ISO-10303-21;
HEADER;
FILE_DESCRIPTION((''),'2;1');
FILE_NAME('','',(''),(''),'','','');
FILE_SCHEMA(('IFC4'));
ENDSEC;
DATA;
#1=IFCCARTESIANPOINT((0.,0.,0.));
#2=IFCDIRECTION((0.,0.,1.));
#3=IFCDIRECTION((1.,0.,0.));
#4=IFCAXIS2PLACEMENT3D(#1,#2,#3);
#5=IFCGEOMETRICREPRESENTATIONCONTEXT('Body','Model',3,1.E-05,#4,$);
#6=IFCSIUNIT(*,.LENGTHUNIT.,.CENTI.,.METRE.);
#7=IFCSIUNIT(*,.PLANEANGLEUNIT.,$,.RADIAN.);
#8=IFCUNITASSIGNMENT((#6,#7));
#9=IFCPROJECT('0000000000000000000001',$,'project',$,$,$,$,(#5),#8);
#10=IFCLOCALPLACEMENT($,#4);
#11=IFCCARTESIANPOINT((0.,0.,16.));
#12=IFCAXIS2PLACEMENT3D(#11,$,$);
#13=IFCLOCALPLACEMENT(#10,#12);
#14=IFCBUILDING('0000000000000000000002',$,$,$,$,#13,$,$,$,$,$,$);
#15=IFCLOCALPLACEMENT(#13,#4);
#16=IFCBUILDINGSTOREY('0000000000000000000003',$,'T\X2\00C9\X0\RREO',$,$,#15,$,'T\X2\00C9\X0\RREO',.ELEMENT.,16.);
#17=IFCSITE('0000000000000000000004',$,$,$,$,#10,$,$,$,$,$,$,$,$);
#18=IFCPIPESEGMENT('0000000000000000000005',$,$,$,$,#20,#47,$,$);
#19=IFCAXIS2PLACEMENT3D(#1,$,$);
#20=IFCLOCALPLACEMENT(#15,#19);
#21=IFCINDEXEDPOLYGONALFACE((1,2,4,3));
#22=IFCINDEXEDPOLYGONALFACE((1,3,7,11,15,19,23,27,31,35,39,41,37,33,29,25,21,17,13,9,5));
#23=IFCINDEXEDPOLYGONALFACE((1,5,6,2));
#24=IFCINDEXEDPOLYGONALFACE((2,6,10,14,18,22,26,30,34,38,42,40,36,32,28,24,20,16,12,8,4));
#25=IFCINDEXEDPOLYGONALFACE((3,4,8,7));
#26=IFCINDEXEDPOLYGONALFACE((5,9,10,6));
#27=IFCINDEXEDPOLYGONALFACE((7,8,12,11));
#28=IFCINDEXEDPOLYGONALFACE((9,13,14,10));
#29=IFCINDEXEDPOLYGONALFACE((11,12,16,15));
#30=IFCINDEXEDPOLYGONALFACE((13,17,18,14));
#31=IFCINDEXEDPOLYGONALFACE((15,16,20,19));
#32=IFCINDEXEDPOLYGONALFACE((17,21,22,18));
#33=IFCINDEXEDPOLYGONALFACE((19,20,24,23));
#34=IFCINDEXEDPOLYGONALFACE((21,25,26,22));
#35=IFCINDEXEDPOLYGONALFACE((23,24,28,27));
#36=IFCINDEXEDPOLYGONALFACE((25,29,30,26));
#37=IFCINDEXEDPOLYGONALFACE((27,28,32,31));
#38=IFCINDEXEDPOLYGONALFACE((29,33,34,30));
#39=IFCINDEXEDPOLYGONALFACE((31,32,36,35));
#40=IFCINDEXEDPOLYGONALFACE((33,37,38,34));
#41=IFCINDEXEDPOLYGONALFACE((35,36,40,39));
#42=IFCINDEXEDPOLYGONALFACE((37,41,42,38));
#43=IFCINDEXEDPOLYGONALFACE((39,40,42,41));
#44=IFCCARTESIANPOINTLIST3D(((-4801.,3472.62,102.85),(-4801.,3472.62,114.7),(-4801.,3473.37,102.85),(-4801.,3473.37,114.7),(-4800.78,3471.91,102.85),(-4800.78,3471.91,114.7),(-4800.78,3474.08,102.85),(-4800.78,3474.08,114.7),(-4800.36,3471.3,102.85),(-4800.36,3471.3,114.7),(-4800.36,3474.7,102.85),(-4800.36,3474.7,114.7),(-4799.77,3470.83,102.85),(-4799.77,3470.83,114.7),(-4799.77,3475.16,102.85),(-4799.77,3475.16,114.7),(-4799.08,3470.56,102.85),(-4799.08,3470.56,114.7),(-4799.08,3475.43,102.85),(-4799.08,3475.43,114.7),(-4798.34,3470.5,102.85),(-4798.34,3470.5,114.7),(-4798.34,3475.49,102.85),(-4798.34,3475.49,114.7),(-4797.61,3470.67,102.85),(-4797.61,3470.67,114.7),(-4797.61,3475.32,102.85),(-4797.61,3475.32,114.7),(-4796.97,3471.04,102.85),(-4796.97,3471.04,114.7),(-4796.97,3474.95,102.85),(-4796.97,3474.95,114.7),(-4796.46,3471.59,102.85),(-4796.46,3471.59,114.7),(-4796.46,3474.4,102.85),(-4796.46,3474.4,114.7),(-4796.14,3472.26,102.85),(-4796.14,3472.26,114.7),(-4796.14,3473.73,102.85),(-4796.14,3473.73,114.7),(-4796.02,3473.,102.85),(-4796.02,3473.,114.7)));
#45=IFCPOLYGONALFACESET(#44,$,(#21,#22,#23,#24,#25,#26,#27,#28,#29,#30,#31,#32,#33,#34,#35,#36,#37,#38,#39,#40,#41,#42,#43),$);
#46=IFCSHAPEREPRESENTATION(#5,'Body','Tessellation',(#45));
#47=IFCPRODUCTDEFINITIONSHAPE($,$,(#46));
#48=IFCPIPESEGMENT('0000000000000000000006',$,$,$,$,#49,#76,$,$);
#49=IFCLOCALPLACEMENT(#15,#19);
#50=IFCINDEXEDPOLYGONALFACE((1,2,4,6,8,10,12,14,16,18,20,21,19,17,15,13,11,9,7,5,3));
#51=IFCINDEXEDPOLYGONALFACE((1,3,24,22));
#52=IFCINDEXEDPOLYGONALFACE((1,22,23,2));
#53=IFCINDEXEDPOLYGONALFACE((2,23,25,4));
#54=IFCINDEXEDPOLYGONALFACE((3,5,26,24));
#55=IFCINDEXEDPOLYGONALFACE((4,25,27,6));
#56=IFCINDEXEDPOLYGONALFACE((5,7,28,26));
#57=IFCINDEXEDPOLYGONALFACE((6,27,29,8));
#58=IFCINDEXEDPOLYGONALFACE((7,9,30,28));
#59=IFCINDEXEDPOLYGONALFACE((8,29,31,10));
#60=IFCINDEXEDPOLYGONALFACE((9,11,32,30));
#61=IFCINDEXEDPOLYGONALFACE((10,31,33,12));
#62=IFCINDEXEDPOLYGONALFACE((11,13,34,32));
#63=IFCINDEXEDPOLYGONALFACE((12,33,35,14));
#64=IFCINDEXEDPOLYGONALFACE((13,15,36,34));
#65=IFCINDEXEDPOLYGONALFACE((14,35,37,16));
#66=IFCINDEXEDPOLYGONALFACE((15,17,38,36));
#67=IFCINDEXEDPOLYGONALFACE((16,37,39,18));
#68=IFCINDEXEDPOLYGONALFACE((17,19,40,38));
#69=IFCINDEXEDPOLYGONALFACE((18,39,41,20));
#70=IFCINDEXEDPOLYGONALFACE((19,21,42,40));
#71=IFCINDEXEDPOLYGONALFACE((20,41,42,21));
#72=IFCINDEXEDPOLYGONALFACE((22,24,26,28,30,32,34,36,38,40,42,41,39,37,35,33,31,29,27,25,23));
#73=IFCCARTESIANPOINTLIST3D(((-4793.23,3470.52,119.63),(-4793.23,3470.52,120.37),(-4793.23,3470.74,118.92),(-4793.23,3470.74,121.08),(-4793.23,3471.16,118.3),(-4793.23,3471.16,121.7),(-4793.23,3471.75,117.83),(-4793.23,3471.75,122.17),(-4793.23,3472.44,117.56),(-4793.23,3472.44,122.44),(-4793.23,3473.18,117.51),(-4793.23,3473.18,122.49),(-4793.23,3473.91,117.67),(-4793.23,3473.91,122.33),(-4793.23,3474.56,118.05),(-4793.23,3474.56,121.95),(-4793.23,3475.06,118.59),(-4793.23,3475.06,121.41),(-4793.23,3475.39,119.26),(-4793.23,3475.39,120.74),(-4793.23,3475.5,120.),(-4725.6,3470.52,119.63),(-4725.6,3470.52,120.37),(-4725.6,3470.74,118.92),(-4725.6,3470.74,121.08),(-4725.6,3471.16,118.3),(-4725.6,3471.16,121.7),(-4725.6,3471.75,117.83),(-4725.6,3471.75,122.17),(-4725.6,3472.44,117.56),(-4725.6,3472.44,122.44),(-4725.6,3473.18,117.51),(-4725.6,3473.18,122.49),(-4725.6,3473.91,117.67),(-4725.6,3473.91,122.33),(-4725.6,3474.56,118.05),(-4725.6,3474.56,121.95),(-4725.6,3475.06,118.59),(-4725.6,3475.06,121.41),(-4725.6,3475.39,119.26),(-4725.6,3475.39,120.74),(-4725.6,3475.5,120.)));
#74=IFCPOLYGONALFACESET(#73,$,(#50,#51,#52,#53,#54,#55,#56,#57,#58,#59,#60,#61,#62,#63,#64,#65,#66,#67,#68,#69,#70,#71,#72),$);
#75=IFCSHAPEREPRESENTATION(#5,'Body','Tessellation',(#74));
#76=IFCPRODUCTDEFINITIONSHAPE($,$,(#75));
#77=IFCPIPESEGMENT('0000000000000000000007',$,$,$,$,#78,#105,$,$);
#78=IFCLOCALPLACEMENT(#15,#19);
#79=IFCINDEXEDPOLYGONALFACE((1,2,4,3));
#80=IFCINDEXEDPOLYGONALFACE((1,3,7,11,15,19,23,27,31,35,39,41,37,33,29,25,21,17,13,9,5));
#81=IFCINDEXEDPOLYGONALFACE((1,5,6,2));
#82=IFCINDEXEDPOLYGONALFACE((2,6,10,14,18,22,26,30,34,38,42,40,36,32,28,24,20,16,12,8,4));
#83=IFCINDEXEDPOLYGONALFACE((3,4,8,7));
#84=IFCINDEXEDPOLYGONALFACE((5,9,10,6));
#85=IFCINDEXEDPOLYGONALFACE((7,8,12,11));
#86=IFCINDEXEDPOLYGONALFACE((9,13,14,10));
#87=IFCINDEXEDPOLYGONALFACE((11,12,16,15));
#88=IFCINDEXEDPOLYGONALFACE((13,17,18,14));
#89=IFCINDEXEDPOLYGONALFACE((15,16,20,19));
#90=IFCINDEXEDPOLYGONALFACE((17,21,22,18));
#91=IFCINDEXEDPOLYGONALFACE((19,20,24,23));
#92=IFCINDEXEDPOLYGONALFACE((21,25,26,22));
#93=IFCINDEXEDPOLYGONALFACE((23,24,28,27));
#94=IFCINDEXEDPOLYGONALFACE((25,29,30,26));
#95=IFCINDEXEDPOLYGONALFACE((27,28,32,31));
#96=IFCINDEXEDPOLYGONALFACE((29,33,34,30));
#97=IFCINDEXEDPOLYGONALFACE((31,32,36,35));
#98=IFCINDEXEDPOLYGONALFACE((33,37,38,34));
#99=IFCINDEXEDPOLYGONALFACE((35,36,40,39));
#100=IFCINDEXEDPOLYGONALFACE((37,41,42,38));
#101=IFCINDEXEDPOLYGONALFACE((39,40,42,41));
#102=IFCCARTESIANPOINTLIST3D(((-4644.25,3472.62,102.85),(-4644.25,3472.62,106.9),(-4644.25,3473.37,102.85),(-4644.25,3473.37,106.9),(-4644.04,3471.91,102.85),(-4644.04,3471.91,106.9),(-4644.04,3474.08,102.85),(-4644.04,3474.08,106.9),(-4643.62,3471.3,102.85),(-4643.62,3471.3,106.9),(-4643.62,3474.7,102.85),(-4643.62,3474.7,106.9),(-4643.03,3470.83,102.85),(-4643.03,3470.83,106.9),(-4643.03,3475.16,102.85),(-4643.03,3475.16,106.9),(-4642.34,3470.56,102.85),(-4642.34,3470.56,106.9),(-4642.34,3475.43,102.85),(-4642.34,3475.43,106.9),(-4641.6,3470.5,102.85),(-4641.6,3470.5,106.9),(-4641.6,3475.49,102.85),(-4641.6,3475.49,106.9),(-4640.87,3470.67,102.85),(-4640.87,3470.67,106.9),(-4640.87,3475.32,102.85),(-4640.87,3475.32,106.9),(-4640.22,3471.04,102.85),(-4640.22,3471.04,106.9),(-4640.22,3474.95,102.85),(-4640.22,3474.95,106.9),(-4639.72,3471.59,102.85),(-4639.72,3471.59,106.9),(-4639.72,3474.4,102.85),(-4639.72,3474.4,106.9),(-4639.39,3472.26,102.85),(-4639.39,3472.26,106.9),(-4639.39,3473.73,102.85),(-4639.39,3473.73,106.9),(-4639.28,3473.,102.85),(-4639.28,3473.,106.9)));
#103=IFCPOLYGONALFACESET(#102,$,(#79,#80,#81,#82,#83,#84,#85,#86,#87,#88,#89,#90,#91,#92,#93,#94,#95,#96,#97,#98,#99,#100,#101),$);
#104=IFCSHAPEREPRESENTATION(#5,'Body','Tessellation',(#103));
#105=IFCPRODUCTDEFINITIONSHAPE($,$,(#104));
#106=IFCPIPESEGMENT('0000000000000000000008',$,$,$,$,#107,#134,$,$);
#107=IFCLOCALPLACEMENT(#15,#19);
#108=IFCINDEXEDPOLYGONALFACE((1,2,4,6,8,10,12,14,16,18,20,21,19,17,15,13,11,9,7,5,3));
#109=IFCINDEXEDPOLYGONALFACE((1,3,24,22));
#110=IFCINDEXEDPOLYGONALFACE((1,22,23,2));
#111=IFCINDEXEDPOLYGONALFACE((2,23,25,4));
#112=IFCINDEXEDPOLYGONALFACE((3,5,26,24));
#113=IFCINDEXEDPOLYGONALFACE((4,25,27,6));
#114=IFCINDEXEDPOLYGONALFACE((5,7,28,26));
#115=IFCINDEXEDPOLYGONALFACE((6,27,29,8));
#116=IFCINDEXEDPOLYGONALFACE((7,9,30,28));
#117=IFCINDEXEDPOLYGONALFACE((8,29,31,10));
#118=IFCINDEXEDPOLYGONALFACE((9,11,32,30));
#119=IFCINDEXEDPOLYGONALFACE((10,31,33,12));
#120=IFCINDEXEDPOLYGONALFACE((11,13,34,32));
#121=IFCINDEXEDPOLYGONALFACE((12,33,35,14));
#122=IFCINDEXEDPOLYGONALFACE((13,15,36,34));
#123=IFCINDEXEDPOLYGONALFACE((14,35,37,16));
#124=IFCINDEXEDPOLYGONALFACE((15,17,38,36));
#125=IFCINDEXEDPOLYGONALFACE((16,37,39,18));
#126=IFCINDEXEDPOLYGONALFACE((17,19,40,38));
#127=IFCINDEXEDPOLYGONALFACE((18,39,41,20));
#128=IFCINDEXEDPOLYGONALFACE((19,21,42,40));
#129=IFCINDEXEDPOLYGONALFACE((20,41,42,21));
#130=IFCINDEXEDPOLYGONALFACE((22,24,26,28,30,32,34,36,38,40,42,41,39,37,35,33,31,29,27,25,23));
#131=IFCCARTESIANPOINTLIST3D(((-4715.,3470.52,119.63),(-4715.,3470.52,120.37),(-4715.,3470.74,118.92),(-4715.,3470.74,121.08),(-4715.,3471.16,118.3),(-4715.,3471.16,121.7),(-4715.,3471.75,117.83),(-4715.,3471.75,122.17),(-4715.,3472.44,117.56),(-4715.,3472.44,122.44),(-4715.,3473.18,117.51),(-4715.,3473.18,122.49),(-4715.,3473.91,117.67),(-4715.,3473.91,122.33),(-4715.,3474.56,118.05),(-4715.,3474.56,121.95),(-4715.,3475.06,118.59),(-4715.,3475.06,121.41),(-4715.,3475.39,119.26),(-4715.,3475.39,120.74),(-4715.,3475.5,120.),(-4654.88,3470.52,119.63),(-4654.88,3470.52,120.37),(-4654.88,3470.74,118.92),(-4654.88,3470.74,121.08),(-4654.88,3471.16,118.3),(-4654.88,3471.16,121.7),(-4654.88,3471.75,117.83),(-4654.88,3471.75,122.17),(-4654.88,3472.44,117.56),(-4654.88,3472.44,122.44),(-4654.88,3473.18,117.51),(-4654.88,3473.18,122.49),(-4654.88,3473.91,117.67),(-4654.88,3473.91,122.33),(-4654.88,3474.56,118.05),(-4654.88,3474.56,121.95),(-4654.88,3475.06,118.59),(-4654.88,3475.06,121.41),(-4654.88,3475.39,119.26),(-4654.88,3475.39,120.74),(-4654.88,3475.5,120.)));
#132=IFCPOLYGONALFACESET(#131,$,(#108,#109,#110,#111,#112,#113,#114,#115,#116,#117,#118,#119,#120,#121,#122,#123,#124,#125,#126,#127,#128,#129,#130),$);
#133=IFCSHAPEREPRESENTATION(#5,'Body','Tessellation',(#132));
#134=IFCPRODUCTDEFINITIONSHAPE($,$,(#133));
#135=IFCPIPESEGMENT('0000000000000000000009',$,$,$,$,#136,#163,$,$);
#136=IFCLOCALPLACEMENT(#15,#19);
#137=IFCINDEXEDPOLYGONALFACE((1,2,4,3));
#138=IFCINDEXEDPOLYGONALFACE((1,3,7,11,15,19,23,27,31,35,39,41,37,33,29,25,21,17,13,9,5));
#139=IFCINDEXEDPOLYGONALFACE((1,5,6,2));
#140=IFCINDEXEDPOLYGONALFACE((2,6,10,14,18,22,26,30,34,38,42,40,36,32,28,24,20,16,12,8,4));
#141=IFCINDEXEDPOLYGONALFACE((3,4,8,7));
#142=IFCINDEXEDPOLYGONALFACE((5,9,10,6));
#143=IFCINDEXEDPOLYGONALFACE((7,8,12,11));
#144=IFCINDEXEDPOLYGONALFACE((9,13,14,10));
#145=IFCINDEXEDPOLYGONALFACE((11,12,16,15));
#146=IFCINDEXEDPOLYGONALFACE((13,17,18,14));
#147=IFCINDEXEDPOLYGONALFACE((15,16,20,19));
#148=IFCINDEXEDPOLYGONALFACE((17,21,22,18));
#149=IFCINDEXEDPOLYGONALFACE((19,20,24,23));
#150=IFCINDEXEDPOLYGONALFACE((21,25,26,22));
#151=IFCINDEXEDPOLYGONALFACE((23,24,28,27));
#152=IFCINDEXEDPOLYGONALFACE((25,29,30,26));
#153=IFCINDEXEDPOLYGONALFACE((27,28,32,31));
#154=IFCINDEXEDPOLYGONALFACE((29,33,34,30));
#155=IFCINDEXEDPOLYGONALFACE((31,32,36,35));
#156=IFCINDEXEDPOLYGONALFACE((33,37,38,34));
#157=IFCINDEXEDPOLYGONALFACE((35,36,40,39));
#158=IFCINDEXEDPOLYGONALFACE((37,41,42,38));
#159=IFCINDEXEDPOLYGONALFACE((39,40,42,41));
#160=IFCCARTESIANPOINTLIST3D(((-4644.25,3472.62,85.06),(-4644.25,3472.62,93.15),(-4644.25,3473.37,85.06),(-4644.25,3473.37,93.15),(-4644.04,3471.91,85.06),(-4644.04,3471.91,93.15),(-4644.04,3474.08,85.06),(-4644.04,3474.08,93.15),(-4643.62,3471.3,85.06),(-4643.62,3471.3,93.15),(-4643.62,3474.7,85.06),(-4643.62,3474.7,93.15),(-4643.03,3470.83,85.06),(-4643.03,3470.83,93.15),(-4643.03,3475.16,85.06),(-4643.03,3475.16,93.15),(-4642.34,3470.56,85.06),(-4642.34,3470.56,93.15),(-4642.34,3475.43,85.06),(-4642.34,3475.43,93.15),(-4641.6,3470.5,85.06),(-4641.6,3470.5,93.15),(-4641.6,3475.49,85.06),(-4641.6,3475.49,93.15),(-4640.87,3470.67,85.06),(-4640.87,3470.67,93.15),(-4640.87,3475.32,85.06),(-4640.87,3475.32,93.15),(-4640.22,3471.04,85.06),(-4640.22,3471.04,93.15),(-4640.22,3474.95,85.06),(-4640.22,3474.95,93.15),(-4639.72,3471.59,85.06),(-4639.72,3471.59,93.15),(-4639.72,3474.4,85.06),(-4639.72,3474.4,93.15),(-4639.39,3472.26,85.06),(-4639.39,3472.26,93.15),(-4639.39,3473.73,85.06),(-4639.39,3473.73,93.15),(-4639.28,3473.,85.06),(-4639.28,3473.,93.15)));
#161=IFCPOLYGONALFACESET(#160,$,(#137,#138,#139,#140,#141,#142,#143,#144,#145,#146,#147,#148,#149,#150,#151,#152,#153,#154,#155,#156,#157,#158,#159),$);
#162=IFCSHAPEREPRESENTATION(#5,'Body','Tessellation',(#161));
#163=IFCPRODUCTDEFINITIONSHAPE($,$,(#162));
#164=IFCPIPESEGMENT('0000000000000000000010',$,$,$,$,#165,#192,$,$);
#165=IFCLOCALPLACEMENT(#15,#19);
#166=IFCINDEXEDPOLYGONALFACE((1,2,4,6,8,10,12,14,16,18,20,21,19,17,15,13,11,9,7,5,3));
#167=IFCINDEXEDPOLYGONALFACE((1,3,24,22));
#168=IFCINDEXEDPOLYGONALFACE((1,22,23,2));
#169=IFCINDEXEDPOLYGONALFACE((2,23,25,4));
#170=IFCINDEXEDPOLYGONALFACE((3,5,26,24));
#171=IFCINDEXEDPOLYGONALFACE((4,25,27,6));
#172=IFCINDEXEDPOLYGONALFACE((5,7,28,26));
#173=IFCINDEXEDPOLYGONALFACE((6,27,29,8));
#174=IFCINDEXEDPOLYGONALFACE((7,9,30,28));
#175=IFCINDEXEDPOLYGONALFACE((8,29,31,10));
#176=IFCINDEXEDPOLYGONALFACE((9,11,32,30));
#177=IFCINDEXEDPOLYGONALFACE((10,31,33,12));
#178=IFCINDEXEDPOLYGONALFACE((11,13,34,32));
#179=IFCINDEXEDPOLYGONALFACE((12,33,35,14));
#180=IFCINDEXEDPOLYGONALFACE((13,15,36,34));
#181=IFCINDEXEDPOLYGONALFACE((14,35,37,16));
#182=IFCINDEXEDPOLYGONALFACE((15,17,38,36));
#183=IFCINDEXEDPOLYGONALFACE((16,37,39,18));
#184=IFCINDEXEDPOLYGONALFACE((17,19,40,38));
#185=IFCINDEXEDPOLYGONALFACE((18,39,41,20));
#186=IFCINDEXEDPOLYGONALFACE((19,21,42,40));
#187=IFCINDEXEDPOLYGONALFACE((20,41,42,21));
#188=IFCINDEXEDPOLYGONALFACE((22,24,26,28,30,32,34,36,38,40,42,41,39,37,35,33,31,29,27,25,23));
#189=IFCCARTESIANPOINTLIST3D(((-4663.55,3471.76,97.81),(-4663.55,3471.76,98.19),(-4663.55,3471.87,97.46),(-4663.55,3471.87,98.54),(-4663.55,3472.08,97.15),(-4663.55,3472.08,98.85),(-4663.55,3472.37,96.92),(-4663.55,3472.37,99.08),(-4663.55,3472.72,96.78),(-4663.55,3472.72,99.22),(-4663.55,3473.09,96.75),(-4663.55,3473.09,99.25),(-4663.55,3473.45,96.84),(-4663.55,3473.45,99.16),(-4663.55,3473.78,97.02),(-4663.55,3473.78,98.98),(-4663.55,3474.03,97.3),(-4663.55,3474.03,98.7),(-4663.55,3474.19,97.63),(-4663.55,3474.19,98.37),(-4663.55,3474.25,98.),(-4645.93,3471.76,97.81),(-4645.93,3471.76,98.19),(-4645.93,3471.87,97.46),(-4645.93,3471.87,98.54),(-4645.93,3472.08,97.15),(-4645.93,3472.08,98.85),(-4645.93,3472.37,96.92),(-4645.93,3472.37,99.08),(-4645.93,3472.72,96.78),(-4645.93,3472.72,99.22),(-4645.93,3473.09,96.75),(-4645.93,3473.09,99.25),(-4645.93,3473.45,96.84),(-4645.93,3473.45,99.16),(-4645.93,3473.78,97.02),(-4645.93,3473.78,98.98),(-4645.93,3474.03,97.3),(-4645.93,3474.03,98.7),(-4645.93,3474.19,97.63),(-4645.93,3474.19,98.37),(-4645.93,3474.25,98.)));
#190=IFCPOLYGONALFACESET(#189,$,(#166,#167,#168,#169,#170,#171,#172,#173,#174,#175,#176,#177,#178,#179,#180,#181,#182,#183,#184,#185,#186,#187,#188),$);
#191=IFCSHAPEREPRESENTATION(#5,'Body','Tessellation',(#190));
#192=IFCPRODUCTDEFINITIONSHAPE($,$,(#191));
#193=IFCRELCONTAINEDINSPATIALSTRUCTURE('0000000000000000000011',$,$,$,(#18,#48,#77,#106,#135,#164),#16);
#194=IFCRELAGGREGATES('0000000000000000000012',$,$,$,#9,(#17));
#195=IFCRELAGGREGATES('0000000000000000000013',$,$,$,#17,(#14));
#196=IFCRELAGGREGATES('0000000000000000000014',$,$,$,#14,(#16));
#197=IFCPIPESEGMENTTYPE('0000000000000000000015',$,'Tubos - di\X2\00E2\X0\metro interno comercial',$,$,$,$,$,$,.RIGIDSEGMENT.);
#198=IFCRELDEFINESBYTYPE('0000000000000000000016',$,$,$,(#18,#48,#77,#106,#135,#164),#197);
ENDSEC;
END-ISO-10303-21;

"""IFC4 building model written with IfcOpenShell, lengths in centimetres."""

from ifc_helpers import new_model, si_unit, frame, origin_with_axes, origin_2d_with_axis, place, context, project, spatial, circle, extrude, type_object, element, save


model = new_model("IFC4")

# Units and contexts
model_context = context("Model", 3, precision=1e-05, world=origin_with_axes(), identifier="Body")
ifc_project = project(units=[si_unit("LENGTHUNIT", "METRE", prefix="CENTI"), si_unit("PLANEANGLEUNIT", "RADIAN")], contexts=[model_context])

# Site, building, storey
site_placement = place(None, origin_with_axes())
site = spatial("IfcSite", under=ifc_project, at=site_placement)
building_placement = place(site_placement, frame((0.0, 0.0, 16.0)))
building = spatial("IfcBuilding", under=site, at=building_placement)
storey_placement = place(building_placement, origin_with_axes())
storey = spatial("IfcBuildingStorey", under=building, at=storey_placement, Name="TÉRREO", LongName="TÉRREO", CompositionType="ELEMENT", Elevation=16.0)

# Pipe segments
pipe_segment_type = type_object("IfcPipeSegmentType", Name="Tubos - diâmetro interno comercial", PredefinedType="RIGIDSEGMENT")
pipe_segment_1_placement = place(storey_placement, frame((-4798.52, 3473.0, 114.7), z_axis=(0.0, 0.0, 1.0), x_axis=(1.0, 0.0, 0.0)))
element("IfcPipeSegment", 1, at=pipe_segment_1_placement, inside=storey, type_object=pipe_segment_type, context=model_context, shape_type="SolidModel", body=[
    extrude(circle(Radius=2.5, at=origin_2d_with_axis()), frame((0.0, 0.0, 0.0), z_axis=(0.0, 0.0, -1.0), x_axis=(1.0, 0.0, 0.0)), (0.0, 0.0, 1.0), 11.85),
])
pipe_segment_2_placement = place(storey_placement, frame((-4759.41, 3473.0, 122.5), z_axis=(0.0, 0.0, 1.0), x_axis=(1.0, 0.0, 0.0)))
element("IfcPipeSegment", 2, at=pipe_segment_2_placement, inside=storey, type_object=pipe_segment_type, context=model_context, shape_type="SolidModel", body=[
    extrude(circle(Radius=2.5, at=origin_2d_with_axis()), frame((-33.81, 0.0, -2.5), z_axis=(1.0, 0.0, 0.0), x_axis=(0.0, 1.0, 0.0)), (0.0, 0.0, 1.0), 67.62),
])
pipe_segment_3_placement = place(storey_placement, frame((-4641.78, 3473.0, 106.9), z_axis=(0.0, 0.0, 1.0), x_axis=(1.0, 0.0, 0.0)))
element("IfcPipeSegment", 3, at=pipe_segment_3_placement, inside=storey, type_object=pipe_segment_type, context=model_context, shape_type="SolidModel", body=[
    extrude(circle(Radius=2.5, at=origin_2d_with_axis()), frame((0.0, 0.0, 0.0), z_axis=(0.0, 0.0, -1.0), x_axis=(1.0, 0.0, 0.0)), (0.0, 0.0, 1.0), 4.05),
])
pipe_segment_4_placement = place(storey_placement, frame((-4684.94, 3473.0, 122.5), z_axis=(0.0, 0.0, 1.0), x_axis=(1.0, 0.0, 0.0)))
element("IfcPipeSegment", 4, at=pipe_segment_4_placement, inside=storey, type_object=pipe_segment_type, context=model_context, shape_type="SolidModel", body=[
    extrude(circle(Radius=2.5, at=origin_2d_with_axis()), frame((-30.06, 0.0, -2.5), z_axis=(1.0, 0.0, 0.0), x_axis=(0.0, 1.0, 0.0)), (0.0, 0.0, 1.0), 60.12),
])
pipe_segment_5_placement = place(storey_placement, frame((-4641.78, 3473.0, 93.15), z_axis=(0.0, 0.0, 1.0), x_axis=(1.0, 0.0, 0.0)))
element("IfcPipeSegment", 5, at=pipe_segment_5_placement, inside=storey, type_object=pipe_segment_type, context=model_context, shape_type="SolidModel", body=[
    extrude(circle(Radius=2.5, at=origin_2d_with_axis()), frame((0.0, 0.0, 0.0), z_axis=(0.0, 0.0, -1.0), x_axis=(1.0, 0.0, 0.0)), (0.0, 0.0, 1.0), 8.09),
])
pipe_segment_6_placement = place(storey_placement, frame((-4654.74, 3473.0, 99.25), z_axis=(0.0, 0.0, 1.0), x_axis=(1.0, 0.0, 0.0)))
element("IfcPipeSegment", 6, at=pipe_segment_6_placement, inside=storey, type_object=pipe_segment_type, context=model_context, shape_type="SolidModel", body=[
    extrude(circle(Radius=1.25, at=origin_2d_with_axis()), frame((8.81, 0.0, -1.25), z_axis=(-1.0, 0.0, 0.0), x_axis=(0.0, 1.0, 0.0)), (0.0, 0.0, 1.0), 17.62),
])

save(model, "model.ifc")
